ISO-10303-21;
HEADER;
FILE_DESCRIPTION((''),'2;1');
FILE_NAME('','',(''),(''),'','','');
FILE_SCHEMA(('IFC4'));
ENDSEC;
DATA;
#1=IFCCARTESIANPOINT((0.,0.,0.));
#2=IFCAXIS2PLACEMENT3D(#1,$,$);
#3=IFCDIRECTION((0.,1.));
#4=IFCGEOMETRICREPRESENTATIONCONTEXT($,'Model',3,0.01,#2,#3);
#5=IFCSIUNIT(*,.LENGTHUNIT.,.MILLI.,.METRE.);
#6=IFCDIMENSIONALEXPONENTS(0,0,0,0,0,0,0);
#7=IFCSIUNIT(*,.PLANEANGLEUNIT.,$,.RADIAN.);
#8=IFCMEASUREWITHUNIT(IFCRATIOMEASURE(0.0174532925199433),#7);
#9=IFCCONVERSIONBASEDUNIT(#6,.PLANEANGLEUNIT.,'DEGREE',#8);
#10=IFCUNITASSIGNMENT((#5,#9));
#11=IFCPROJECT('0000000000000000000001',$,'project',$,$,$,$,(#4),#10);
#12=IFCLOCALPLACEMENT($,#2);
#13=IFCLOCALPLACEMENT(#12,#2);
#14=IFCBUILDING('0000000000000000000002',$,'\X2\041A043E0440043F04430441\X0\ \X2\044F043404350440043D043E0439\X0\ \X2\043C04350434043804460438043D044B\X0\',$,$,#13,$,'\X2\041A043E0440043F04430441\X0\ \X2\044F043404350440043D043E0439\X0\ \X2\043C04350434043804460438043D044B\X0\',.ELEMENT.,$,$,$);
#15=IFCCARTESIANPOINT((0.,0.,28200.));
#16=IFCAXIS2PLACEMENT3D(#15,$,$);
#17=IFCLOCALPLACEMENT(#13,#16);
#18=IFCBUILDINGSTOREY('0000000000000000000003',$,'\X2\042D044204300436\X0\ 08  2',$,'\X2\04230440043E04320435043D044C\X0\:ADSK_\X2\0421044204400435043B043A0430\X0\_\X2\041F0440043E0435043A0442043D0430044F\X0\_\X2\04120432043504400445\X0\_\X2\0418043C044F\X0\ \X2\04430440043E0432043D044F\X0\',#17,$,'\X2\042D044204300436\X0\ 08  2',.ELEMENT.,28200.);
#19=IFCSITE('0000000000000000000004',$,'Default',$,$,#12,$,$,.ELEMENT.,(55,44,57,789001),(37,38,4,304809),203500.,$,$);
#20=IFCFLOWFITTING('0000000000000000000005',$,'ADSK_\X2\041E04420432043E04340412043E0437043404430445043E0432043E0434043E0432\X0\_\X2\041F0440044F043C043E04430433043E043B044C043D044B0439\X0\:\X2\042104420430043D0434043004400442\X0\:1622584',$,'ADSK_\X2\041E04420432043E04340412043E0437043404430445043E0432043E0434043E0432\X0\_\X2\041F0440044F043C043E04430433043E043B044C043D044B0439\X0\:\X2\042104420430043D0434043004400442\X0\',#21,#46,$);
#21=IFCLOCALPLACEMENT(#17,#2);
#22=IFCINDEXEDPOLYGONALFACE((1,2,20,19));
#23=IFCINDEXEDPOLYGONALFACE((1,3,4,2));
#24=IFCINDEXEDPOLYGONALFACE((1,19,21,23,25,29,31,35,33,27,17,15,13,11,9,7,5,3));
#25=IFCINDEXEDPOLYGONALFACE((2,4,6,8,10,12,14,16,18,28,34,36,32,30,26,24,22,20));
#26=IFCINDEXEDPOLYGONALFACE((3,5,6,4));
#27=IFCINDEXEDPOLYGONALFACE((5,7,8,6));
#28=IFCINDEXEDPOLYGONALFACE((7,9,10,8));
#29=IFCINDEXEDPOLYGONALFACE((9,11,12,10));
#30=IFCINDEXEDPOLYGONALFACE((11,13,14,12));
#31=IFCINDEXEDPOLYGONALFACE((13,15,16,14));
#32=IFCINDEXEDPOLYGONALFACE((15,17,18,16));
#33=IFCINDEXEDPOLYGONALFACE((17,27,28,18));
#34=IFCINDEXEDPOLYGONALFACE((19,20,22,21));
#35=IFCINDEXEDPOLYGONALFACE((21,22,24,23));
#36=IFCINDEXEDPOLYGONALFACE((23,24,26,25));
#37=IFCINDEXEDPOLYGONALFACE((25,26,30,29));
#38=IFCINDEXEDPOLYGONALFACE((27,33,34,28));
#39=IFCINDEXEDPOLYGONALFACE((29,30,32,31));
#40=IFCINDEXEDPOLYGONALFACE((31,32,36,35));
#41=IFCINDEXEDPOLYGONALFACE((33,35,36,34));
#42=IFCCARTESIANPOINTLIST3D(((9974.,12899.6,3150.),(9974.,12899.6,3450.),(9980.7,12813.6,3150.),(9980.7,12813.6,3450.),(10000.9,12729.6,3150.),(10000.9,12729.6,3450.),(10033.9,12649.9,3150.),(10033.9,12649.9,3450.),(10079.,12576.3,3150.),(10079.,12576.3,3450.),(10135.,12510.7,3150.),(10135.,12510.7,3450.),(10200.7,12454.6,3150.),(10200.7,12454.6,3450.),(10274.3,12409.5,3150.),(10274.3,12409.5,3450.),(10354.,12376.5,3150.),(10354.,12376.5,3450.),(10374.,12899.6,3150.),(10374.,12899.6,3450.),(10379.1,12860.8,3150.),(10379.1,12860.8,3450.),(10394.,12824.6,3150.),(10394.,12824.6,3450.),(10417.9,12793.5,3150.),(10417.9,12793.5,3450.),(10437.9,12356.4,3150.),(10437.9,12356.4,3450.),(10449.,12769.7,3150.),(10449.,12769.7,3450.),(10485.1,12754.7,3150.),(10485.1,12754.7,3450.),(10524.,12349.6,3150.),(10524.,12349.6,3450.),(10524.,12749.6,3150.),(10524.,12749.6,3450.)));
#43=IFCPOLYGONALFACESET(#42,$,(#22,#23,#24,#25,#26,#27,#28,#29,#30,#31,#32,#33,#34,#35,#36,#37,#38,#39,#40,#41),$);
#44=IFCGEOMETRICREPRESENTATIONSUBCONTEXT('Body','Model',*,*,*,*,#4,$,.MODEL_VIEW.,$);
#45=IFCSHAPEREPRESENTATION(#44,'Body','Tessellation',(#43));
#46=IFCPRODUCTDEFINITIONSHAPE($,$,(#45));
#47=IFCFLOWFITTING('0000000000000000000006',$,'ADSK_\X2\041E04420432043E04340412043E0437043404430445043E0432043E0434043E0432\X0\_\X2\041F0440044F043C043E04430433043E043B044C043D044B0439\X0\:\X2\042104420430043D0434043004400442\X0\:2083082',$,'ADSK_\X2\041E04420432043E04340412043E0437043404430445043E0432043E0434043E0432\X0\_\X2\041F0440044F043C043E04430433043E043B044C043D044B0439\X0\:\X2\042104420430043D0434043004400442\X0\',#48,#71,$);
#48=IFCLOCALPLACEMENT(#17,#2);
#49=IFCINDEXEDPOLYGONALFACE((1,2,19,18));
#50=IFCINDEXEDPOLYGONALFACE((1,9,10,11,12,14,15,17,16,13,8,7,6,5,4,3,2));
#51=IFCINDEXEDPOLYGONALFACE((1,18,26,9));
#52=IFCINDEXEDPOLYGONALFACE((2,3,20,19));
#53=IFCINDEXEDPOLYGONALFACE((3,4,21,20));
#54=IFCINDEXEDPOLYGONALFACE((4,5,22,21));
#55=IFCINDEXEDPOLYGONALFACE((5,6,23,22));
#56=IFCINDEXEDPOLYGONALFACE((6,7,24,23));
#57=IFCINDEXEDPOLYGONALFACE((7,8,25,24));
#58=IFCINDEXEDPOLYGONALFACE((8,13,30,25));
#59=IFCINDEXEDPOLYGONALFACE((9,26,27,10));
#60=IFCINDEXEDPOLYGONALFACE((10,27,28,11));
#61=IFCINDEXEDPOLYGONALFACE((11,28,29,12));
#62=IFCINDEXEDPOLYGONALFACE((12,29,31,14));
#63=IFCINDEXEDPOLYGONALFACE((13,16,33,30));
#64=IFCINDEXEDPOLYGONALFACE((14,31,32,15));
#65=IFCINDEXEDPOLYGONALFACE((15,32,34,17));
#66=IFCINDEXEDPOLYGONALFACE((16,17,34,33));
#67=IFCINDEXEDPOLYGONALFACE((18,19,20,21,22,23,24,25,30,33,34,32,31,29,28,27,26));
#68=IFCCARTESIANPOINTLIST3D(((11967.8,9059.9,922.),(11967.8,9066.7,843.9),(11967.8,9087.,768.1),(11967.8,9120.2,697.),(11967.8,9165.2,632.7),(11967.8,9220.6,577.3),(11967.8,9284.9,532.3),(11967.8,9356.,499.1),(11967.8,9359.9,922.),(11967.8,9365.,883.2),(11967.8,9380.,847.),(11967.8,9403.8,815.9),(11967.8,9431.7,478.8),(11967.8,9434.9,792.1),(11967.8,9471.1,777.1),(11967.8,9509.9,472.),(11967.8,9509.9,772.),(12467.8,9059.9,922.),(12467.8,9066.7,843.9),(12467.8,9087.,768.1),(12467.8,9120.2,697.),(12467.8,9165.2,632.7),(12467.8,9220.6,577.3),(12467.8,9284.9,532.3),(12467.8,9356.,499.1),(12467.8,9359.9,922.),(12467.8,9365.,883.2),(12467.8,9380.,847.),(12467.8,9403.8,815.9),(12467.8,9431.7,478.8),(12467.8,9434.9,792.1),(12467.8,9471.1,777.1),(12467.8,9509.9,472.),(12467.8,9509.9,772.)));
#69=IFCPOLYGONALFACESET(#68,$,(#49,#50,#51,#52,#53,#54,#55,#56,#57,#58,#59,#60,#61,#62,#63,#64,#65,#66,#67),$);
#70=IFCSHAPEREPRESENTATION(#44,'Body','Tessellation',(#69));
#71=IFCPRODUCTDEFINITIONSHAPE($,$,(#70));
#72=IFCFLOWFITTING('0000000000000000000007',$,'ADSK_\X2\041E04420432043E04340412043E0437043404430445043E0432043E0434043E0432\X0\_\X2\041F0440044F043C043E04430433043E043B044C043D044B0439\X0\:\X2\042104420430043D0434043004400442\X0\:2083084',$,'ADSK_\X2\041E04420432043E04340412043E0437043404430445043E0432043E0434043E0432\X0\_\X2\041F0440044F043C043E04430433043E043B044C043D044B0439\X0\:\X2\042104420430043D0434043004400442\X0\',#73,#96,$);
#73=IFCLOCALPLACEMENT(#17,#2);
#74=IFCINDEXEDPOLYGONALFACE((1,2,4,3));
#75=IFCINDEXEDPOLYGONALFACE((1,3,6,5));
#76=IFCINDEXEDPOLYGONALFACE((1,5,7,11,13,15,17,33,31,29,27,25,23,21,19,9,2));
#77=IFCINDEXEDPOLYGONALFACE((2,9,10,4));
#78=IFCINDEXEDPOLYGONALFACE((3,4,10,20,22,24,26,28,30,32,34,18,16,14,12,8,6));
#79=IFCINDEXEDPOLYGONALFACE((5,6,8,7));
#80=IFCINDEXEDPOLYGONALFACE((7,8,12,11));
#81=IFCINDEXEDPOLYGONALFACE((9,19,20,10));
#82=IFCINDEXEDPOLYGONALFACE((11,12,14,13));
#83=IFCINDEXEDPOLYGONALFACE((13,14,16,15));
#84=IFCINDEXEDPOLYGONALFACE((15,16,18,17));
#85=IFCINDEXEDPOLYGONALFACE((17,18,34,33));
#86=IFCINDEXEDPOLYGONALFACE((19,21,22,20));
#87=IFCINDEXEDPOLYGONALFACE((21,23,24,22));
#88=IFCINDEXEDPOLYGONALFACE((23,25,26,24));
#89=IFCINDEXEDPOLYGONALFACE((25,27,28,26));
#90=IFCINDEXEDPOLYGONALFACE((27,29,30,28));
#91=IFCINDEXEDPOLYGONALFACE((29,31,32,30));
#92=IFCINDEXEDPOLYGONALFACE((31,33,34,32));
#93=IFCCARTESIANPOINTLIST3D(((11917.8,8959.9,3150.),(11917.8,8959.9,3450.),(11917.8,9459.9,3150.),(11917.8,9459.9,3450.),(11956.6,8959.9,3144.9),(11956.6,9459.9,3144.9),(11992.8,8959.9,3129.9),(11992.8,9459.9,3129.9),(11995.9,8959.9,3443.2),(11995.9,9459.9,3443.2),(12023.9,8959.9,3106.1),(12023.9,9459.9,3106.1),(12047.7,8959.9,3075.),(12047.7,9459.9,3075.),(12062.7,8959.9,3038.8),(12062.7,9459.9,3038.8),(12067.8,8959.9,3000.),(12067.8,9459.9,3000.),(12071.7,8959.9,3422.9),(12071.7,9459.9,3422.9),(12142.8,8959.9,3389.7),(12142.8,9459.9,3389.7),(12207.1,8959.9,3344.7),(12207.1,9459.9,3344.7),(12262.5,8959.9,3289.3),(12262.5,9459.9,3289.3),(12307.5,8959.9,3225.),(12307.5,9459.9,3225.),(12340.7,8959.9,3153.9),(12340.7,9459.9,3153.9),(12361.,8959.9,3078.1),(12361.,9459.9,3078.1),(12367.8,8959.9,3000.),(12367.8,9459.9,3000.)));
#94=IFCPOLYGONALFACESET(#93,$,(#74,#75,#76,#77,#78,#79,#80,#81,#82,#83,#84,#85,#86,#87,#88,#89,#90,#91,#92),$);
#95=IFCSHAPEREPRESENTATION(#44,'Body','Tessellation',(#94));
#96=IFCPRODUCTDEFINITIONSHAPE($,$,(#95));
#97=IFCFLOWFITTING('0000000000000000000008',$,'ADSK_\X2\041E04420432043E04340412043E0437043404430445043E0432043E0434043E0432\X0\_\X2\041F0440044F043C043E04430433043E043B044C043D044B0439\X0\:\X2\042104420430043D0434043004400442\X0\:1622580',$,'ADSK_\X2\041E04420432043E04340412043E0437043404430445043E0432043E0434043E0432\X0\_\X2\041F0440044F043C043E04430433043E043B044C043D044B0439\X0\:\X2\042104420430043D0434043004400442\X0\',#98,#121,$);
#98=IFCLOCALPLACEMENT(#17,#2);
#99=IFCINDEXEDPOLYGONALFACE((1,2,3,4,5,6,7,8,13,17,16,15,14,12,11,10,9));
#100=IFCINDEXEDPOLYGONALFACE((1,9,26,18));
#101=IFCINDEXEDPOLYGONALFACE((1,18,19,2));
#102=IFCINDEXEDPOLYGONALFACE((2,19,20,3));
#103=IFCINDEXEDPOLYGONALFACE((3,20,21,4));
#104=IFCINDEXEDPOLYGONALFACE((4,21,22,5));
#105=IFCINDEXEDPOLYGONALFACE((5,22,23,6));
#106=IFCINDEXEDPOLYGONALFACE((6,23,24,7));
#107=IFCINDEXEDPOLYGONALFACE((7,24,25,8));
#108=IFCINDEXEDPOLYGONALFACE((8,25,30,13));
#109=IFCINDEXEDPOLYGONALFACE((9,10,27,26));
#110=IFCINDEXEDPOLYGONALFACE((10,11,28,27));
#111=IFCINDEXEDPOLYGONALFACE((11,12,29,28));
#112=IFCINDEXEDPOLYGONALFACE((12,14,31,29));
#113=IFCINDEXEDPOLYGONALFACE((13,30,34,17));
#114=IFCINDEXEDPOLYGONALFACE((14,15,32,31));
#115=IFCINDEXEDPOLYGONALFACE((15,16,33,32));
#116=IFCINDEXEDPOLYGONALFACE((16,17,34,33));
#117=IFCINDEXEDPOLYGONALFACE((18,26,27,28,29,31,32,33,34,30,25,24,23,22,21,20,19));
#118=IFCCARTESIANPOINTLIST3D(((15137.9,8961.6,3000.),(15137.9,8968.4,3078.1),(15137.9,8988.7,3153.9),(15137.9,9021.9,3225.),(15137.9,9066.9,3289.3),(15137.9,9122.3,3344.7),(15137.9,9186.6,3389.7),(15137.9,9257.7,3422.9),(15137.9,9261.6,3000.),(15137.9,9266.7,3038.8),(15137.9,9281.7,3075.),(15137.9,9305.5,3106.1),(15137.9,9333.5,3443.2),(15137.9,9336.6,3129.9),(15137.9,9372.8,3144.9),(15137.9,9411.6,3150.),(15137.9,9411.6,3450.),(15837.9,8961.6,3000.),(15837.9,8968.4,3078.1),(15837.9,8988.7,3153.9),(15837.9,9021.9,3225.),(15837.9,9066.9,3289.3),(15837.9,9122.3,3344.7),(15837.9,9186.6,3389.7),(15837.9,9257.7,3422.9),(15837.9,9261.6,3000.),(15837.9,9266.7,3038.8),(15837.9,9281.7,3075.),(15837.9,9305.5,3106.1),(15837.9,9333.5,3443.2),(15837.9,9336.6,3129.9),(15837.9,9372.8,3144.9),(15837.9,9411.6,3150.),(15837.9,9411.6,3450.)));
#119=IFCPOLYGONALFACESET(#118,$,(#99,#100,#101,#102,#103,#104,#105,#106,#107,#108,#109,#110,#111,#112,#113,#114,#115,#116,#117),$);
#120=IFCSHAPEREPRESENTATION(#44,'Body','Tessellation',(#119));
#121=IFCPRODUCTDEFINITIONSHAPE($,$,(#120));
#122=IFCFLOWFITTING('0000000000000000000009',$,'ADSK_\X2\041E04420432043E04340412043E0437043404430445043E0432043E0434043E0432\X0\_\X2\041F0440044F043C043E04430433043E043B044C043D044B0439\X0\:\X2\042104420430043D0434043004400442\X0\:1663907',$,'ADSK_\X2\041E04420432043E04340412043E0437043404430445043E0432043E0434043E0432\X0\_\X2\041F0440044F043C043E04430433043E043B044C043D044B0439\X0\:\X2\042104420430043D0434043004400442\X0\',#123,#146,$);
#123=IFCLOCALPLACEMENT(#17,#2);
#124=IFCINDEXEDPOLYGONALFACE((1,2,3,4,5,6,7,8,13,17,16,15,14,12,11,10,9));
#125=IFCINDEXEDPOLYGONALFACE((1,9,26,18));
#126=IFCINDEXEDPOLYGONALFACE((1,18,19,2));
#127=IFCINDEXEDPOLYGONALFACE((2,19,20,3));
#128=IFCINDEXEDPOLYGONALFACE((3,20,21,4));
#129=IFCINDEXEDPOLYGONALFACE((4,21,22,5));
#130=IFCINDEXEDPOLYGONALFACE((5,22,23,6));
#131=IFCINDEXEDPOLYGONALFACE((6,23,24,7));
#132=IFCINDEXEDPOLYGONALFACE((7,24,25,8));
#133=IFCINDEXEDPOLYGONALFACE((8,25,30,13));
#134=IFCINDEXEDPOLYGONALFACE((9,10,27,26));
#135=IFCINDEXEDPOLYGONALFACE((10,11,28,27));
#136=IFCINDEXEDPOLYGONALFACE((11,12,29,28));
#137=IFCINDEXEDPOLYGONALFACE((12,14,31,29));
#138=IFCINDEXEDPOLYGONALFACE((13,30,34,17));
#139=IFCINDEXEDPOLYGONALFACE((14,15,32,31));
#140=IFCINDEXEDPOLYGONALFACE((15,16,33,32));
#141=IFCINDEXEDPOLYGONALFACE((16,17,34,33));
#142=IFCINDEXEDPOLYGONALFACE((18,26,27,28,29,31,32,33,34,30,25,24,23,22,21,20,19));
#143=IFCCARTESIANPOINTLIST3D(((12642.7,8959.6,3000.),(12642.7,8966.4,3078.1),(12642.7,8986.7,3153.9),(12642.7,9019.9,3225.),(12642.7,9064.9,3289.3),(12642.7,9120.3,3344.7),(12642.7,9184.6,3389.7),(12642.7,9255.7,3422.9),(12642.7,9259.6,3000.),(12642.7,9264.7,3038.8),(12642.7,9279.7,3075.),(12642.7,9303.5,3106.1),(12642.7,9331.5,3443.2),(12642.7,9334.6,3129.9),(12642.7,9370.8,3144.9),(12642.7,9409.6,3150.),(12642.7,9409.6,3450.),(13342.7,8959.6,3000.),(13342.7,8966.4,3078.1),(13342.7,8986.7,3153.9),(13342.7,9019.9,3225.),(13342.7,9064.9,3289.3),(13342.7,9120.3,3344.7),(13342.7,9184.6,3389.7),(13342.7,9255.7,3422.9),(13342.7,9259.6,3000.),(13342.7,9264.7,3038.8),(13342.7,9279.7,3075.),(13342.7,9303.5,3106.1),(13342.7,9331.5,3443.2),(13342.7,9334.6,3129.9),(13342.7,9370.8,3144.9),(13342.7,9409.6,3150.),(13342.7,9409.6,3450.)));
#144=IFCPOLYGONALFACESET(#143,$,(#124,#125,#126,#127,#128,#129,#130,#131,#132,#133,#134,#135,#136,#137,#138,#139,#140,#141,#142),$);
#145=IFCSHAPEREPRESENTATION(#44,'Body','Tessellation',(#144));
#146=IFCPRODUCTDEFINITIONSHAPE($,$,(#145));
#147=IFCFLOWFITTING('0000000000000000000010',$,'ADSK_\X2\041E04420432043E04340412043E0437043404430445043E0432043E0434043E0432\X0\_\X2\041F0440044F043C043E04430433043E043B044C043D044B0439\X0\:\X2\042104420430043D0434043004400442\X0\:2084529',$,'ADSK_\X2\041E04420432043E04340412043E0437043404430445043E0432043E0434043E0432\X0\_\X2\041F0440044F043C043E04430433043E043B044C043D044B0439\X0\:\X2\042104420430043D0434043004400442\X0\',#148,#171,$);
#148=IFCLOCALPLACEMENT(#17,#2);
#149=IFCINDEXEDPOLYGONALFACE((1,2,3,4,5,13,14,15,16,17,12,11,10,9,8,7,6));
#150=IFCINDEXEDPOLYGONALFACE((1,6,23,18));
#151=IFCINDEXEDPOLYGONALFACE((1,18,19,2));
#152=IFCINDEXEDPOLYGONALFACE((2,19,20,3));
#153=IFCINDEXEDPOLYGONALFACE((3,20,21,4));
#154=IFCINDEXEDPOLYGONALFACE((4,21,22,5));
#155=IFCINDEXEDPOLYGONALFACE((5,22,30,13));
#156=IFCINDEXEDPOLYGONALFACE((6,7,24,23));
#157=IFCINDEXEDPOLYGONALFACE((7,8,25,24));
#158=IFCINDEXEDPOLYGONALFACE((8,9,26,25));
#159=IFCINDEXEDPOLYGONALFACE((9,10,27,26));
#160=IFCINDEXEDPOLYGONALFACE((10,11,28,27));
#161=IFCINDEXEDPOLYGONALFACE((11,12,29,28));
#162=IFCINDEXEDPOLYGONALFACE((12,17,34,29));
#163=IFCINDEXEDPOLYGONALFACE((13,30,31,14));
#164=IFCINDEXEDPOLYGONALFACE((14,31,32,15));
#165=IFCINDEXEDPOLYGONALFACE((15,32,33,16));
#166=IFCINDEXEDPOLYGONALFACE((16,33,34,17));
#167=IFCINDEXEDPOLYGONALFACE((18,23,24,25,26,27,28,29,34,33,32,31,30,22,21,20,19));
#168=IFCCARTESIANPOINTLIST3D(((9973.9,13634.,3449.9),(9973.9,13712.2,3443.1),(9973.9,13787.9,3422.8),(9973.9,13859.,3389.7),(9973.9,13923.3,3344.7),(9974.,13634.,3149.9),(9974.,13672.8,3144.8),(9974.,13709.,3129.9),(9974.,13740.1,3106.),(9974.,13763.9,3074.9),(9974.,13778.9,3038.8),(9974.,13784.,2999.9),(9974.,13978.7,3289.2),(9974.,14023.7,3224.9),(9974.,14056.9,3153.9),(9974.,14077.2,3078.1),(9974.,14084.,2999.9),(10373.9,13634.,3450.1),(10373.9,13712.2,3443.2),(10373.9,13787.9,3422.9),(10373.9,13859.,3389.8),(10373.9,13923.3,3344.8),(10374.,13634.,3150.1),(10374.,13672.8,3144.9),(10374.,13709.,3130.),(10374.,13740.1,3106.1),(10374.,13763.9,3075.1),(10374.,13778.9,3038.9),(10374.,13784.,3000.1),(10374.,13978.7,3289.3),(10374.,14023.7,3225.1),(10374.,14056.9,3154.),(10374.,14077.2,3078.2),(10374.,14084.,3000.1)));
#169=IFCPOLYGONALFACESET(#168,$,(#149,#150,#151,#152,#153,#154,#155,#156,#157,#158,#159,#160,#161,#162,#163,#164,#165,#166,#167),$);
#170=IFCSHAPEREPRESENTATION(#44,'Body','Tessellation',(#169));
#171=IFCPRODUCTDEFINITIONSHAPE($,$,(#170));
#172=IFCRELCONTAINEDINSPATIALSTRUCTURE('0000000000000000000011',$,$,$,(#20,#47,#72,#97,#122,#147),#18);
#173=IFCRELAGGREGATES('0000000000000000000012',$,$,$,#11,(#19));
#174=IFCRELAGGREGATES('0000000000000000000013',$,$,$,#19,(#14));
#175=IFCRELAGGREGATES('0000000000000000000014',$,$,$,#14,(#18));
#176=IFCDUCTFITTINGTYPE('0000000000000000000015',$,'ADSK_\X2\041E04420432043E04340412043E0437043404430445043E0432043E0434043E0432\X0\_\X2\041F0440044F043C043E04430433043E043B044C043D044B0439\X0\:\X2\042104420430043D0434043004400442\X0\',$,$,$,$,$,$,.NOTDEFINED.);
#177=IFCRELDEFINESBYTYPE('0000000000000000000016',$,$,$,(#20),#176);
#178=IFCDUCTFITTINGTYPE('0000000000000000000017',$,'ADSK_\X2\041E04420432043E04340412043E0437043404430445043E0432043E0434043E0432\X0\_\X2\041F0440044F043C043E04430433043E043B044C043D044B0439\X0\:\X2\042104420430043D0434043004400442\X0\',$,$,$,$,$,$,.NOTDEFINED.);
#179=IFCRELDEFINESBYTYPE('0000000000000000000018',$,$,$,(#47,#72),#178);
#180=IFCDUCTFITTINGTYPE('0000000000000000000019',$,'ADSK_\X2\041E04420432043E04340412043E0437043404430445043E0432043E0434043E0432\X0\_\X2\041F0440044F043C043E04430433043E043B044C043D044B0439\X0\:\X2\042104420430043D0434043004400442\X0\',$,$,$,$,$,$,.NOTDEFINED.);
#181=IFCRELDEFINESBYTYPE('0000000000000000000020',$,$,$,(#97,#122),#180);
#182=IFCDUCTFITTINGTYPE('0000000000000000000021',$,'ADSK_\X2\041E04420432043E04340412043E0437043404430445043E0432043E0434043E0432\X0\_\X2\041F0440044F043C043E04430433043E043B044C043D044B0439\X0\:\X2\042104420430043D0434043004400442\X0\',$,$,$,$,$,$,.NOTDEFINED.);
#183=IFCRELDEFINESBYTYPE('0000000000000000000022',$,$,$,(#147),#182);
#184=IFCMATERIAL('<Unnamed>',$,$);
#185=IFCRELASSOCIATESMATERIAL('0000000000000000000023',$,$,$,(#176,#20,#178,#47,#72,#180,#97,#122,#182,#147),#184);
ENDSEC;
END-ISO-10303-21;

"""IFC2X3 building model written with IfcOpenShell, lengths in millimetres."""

from ifc_helpers import new_model, entity, si_unit, converted_unit, direction, frame, frame_2d, origin, place, context, subcontext, project, spatial, polyline, circle_curve, parameter, trimmed, segment, composite_curve, outline, extrude, source, transform, mapped, material, type_object, type_shapes, element, save


model = new_model("IFC2X3")

# Units and contexts
model_context = context("Model", 3, precision=0.01, world=origin(), true_north=direction((0.0, 1.0)))
body_context = subcontext(model_context, "Body", "Model", "MODEL_VIEW")
ifc_project = project(units=[si_unit("LENGTHUNIT", "METRE", prefix="MILLI"), converted_unit("PLANEANGLEUNIT", "DEGREE", entity("IfcRatioMeasure", 0.0174532925199433), si_unit("PLANEANGLEUNIT", "RADIAN"), dimensions=[0, 0, 0, 0, 0, 0, 0])], contexts=[model_context])

# Site, building, storey
site_placement = place(None, origin())
site = spatial("IfcSite", under=ifc_project, at=site_placement, Name="Default", CompositionType="ELEMENT", RefLatitude=(55, 44, 57, 789001), RefLongitude=(37, 38, 4, 304809), RefElevation=203500.0)
building_placement = place(site_placement, origin())
building = spatial("IfcBuilding", under=site, at=building_placement, Name="Корпус ядерной медицины", LongName="Корпус ядерной медицины", CompositionType="ELEMENT")
storey_placement = place(building_placement, frame((0.0, 0.0, 28200.0)))
storey = spatial("IfcBuildingStorey", under=building, at=storey_placement, Name="Этаж 08  2", ObjectType="Уровень:ADSK_Стрелка_Проектная_Вверх_Имя уровня", LongName="Этаж 08  2", CompositionType="ELEMENT", Elevation=28200.0)

# Flow fittings
ifc_material = material(Name="<Unnamed>")
duct_fitting_type_1 = type_object("IfcDuctFittingType", Name="ADSK_ОтводВоздуховодов_Прямоугольный:Стандарт", PredefinedType="NOTDEFINED", material=ifc_material)
shared_shape_1 = source(origin(), body_context, "Body", "SweptSolid", [
    extrude(outline(composite_curve([segment(polyline([(-375.0, -175.0), (25.0, -175.0)]), True, "CONTINUOUS"), segment(trimmed(circle_curve(frame_2d((175.0, -175.0), x_axis=(0.0, 1.0)), 150.0), [parameter(0.0)], [parameter(90.0)], True, "PARAMETER"), False, "CONTINUOUS"), segment(polyline([(175.0, -25.0), (175.0, 375.0)]), True, "CONTINUOUS"), segment(trimmed(circle_curve(frame_2d((175.0, -175.0), x_axis=(0.0, 1.0)), 550.0), [parameter(0.0)], [parameter(90.0)], True, "PARAMETER"), True, "CONTINUOUS")], self_intersect=False)), frame((-175.0, 175.0, -150.0), z_axis=(0.0, 0.0, 1.0), x_axis=(-1.0, 0.0, 0.0)), (0.0, 0.0, 1.0), 300.0),
])
type_shapes(duct_fitting_type_1, [shared_shape_1])
flow_fitting_1_placement = place(storey_placement, frame((10174.0, 12549.6, 3300.0), z_axis=(0.0, 0.0, 1.0), x_axis=(0.0, -1.0, 0.0)))
element("IfcFlowFitting", 1, at=flow_fitting_1_placement, inside=storey, type_object=duct_fitting_type_1, material=ifc_material, Name="ADSK_ОтводВоздуховодов_Прямоугольный:Стандарт:1622584", ObjectType="ADSK_ОтводВоздуховодов_Прямоугольный:Стандарт", context=body_context, shape_type="MappedRepresentation", body=[
    mapped(shared_shape_1, transform((0.0, 0.0, 0.0), scale=1.0)),
])
duct_fitting_type_2 = type_object("IfcDuctFittingType", Name="ADSK_ОтводВоздуховодов_Прямоугольный:Стандарт", PredefinedType="NOTDEFINED", material=ifc_material)
shared_shape_2 = source(origin(), body_context, "Body", "SweptSolid", [
    extrude(outline(composite_curve([segment(polyline([(-300.0, -150.0), (0.0, -150.0)]), True, "CONTINUOUS"), segment(trimmed(circle_curve(frame_2d((150.0, -150.0), x_axis=(0.0, 1.0)), 150.0), [parameter(0.0)], [parameter(90.0)], True, "PARAMETER"), False, "CONTINUOUS"), segment(polyline([(150.0, 0.0), (150.0, 300.0)]), True, "CONTINUOUS"), segment(trimmed(circle_curve(frame_2d((150.0, -150.0), x_axis=(0.0, 1.0)), 450.0), [parameter(0.0)], [parameter(90.0)], True, "PARAMETER"), True, "CONTINUOUS")], self_intersect=False)), frame((-150.0, 150.0, -250.0), z_axis=(0.0, 0.0, 1.0), x_axis=(-1.0, 0.0, 0.0)), (0.0, 0.0, 1.0), 500.0),
])
type_shapes(duct_fitting_type_2, [shared_shape_2])
for number, where, z_axis, x_axis, name in (
    (2, (12217.8, 9209.9, 622.0), (-1.0, 0.0, 0.0), (0.0, -1.0, 0.0), "ADSK_ОтводВоздуховодов_Прямоугольный:Стандарт:2083082"),
    (3, (12217.8, 9209.9, 3300.0), (0.0, 1.0, 0.0), (1.0, 0.0, 0.0), "ADSK_ОтводВоздуховодов_Прямоугольный:Стандарт:2083084"),
):
    element("IfcFlowFitting", number, at=place(storey_placement, frame(where, z_axis=z_axis, x_axis=x_axis)), inside=storey, type_object=duct_fitting_type_2, material=ifc_material, Name=name, ObjectType="ADSK_ОтводВоздуховодов_Прямоугольный:Стандарт", context=body_context, shape_type="MappedRepresentation", body=[
        mapped(shared_shape_2, transform((0.0, 0.0, 0.0), scale=1.0)),
    ])
duct_fitting_type_3 = type_object("IfcDuctFittingType", Name="ADSK_ОтводВоздуховодов_Прямоугольный:Стандарт", PredefinedType="NOTDEFINED", material=ifc_material)
shared_shape_3 = source(origin(), body_context, "Body", "SweptSolid", [
    extrude(outline(composite_curve([segment(polyline([(-300.0, -150.0), (0.0, -150.0)]), True, "CONTINUOUS"), segment(trimmed(circle_curve(frame_2d((150.0, -150.0), x_axis=(0.0, 1.0)), 150.0), [parameter(0.0)], [parameter(90.0)], True, "PARAMETER"), False, "CONTINUOUS"), segment(polyline([(150.0, 0.0), (150.0, 300.0)]), True, "CONTINUOUS"), segment(trimmed(circle_curve(frame_2d((150.0, -150.0), x_axis=(0.0, 1.0)), 450.0), [parameter(0.0)], [parameter(90.0)], True, "PARAMETER"), True, "CONTINUOUS")], self_intersect=False)), frame((-150.0, 150.0, -350.0), z_axis=(0.0, 0.0, 1.0), x_axis=(-1.0, 0.0, 0.0)), (0.0, 0.0, 1.0), 700.0),
])
type_shapes(duct_fitting_type_3, [shared_shape_3])
for number, where, z_axis, x_axis, name in (
    (4, (15487.9, 9111.6, 3300.0), (-1.0, 0.0, 0.0), (0.0, 0.0, 1.0), "ADSK_ОтводВоздуховодов_Прямоугольный:Стандарт:1622580"),
    (5, (12992.7, 9109.6, 3300.0), (-1.0, 0.0, 0.0), (0.0, 0.0, 1.0), "ADSK_ОтводВоздуховодов_Прямоугольный:Стандарт:1663907"),
):
    element("IfcFlowFitting", number, at=place(storey_placement, frame(where, z_axis=z_axis, x_axis=x_axis)), inside=storey, type_object=duct_fitting_type_3, material=ifc_material, Name=name, ObjectType="ADSK_ОтводВоздуховодов_Прямоугольный:Стандарт", context=body_context, shape_type="MappedRepresentation", body=[
        mapped(shared_shape_3, transform((0.0, 0.0, 0.0), scale=1.0)),
    ])
duct_fitting_type_4 = type_object("IfcDuctFittingType", Name="ADSK_ОтводВоздуховодов_Прямоугольный:Стандарт", PredefinedType="NOTDEFINED", material=ifc_material)
shared_shape_4 = source(origin(), body_context, "Body", "SweptSolid", [
    extrude(outline(composite_curve([segment(polyline([(-300.0, -150.0), (0.0, -150.0)]), True, "CONTINUOUS"), segment(trimmed(circle_curve(frame_2d((150.0, -150.0), x_axis=(0.0, 1.0)), 150.0), [parameter(0.0)], [parameter(90.0)], True, "PARAMETER"), False, "CONTINUOUS"), segment(polyline([(150.0, 0.0), (150.0, 300.0)]), True, "CONTINUOUS"), segment(trimmed(circle_curve(frame_2d((150.0, -150.0), x_axis=(0.0, 1.0)), 450.0), [parameter(0.0)], [parameter(90.0)], True, "PARAMETER"), True, "CONTINUOUS")], self_intersect=False)), frame((-150.0, 150.0, -200.0), z_axis=(0.0, 0.0, 1.0), x_axis=(-1.0, 0.0, 0.0)), (0.0, 0.0, 1.0), 400.0),
])
type_shapes(duct_fitting_type_4, [shared_shape_4])
flow_fitting_2_placement = place(storey_placement, frame((10174.0, 13934.0, 3300.0), z_axis=(-1.0, 0.0, -0.000256), x_axis=(0.0, 1.0, 0.0)))
element("IfcFlowFitting", 6, at=flow_fitting_2_placement, inside=storey, type_object=duct_fitting_type_4, material=ifc_material, Name="ADSK_ОтводВоздуховодов_Прямоугольный:Стандарт:2084529", ObjectType="ADSK_ОтводВоздуховодов_Прямоугольный:Стандарт", context=body_context, shape_type="MappedRepresentation", body=[
    mapped(shared_shape_4, transform((0.0, 0.0, 0.0), scale=1.0)),
])

save(model, "model.ifc")
